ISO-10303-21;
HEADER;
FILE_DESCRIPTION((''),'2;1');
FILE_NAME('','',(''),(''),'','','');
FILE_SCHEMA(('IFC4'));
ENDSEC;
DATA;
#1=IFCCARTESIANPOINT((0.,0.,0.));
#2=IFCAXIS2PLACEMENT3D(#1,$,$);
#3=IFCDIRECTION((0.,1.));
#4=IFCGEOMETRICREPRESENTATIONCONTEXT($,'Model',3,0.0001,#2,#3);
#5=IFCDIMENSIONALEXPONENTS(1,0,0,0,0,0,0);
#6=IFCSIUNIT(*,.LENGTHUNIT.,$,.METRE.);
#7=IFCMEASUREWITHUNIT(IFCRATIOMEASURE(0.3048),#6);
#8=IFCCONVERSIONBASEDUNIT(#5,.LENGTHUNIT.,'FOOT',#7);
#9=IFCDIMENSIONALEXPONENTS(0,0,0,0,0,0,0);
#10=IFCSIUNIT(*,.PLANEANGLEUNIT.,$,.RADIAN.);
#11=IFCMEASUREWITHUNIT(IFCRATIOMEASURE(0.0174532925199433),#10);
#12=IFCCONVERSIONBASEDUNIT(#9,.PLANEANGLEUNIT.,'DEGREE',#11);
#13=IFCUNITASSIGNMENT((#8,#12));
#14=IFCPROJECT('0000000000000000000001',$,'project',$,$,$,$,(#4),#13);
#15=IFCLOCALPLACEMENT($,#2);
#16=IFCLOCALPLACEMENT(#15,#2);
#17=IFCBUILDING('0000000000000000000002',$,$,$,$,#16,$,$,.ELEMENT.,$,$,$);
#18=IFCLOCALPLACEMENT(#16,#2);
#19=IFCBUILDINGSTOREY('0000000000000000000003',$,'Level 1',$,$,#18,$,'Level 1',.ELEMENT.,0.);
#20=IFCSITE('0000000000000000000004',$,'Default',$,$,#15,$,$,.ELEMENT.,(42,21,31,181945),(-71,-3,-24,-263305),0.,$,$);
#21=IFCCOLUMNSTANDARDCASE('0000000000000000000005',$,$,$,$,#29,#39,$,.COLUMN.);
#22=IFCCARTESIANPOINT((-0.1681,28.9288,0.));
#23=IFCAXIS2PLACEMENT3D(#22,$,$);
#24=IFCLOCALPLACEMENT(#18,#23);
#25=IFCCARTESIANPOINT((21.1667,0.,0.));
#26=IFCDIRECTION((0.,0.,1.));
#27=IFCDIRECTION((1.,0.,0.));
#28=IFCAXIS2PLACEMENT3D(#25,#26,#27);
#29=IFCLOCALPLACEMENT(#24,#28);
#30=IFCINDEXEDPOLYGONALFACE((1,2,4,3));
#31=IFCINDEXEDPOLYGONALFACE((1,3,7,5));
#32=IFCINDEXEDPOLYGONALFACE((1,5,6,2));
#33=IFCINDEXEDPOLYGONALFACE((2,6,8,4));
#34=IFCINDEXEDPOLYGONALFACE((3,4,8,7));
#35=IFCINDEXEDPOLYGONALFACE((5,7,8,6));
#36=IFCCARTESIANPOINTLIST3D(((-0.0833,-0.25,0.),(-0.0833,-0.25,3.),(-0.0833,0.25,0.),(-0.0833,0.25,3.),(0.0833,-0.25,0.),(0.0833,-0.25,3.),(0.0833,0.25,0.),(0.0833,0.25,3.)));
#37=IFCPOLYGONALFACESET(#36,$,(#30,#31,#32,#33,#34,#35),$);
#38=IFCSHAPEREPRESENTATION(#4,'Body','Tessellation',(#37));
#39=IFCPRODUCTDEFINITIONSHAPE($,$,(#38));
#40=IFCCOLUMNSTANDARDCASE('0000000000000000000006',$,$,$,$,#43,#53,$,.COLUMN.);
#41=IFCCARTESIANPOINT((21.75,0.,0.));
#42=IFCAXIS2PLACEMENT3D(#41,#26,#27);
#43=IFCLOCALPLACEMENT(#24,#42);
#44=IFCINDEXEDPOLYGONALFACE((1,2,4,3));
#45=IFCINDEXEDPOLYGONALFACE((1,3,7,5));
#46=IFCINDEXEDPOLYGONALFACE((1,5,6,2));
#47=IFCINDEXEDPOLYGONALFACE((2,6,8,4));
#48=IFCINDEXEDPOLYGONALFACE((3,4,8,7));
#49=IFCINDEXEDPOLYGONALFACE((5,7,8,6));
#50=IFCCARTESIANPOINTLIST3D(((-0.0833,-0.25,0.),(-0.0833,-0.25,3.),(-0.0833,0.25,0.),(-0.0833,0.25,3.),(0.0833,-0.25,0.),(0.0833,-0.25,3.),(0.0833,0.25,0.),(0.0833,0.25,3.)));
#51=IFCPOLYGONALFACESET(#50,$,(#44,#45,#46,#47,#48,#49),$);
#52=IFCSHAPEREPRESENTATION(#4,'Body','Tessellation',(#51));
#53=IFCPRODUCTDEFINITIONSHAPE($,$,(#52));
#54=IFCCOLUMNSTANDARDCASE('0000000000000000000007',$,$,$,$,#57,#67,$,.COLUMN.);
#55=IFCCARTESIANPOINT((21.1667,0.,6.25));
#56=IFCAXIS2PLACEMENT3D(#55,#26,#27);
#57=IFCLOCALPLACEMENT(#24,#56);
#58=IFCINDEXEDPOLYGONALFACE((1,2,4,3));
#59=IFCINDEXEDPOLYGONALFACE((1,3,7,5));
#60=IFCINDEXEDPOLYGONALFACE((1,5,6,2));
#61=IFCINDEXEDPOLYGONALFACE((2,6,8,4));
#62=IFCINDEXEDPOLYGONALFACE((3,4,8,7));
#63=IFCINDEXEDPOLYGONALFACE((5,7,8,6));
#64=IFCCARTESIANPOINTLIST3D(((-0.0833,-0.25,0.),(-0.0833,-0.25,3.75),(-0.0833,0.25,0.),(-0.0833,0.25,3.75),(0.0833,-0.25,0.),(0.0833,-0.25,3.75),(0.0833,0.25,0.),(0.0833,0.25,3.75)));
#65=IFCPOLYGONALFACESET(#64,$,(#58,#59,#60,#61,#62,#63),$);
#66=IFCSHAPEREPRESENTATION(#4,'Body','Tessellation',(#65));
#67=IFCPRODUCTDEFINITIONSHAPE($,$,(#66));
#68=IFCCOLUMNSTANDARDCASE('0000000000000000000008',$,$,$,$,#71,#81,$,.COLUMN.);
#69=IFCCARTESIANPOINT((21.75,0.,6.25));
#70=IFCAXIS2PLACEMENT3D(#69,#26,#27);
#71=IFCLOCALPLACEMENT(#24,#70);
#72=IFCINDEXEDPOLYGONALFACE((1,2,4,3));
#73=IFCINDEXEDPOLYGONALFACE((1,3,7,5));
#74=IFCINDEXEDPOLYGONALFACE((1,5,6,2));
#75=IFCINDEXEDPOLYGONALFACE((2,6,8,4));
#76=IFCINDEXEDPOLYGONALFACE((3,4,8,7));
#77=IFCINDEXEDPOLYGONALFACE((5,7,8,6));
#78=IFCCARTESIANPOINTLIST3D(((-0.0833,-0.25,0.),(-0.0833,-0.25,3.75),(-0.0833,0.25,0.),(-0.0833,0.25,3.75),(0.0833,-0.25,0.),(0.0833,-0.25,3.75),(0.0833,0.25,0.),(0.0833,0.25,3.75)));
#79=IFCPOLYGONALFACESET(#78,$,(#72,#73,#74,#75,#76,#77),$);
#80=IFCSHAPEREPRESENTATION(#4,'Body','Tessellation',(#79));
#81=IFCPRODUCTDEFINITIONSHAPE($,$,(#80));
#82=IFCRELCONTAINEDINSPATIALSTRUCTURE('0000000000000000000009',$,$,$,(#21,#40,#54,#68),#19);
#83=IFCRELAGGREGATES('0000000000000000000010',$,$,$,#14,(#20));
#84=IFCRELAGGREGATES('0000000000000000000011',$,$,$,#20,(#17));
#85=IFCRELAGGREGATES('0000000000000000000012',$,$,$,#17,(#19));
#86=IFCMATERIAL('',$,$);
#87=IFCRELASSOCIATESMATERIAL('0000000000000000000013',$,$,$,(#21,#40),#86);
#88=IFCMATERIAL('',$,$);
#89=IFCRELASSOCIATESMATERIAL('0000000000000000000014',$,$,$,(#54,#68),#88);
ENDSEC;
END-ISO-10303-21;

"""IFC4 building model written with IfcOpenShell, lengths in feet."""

from ifc_helpers import new_model, entity, si_unit, converted_unit, direction, frame, origin, place, context, project, spatial, rectangle, extrude, material, element, save


model = new_model("IFC4")

# Units and contexts
model_context = context("Model", 3, precision=0.0001, world=origin(), true_north=direction((0.0, 1.0)))
ifc_project = project(units=[converted_unit("LENGTHUNIT", "FOOT", entity("IfcRatioMeasure", 0.3048), si_unit("LENGTHUNIT", "METRE"), dimensions=[1, 0, 0, 0, 0, 0, 0]), converted_unit("PLANEANGLEUNIT", "DEGREE", entity("IfcRatioMeasure", 0.0174532925199433), si_unit("PLANEANGLEUNIT", "RADIAN"), dimensions=[0, 0, 0, 0, 0, 0, 0])], contexts=[model_context])

# Site, building, storey
site_placement = place(None, origin())
site = spatial("IfcSite", under=ifc_project, at=site_placement, Name="Default", CompositionType="ELEMENT", RefLatitude=(42, 21, 31, 181945), RefLongitude=(-71, -3, -24, -263305), RefElevation=0.0)
building_placement = place(site_placement, origin())
building = spatial("IfcBuilding", under=site, at=building_placement, CompositionType="ELEMENT")
storey_placement = place(building_placement, origin())
storey = spatial("IfcBuildingStorey", under=building, at=storey_placement, Name="Level 1", LongName="Level 1", CompositionType="ELEMENT", Elevation=0.0)

# Columns
ifc_material_1 = material(Name="")
placement = place(storey_placement, frame((-0.1681, 28.9288, 0.0)))
for number, where, z_axis, x_axis in (
    (1, (21.1667, 0.0, 0.0), (0.0, 0.0, 1.0), (1.0, 0.0, 0.0)),
    (2, (21.75, 0.0, 0.0), (0.0, 0.0, 1.0), (1.0, 0.0, 0.0)),
):
    element("IfcColumnStandardCase", number, at=place(placement, frame(where, z_axis=z_axis, x_axis=x_axis)), inside=storey, material=ifc_material_1, PredefinedType="COLUMN", context=model_context, shape_type="SweptSolid", body=[
        extrude(rectangle(XDim=0.1667, YDim=0.5), origin(), (0.0, 0.0, 1.0), 3.0),
    ])
ifc_material_2 = material(Name="")
for number, where, z_axis, x_axis in (
    (3, (21.1667, 0.0, 6.25), (0.0, 0.0, 1.0), (1.0, 0.0, 0.0)),
    (4, (21.75, 0.0, 6.25), (0.0, 0.0, 1.0), (1.0, 0.0, 0.0)),
):
    element("IfcColumnStandardCase", number, at=place(placement, frame(where, z_axis=z_axis, x_axis=x_axis)), inside=storey, material=ifc_material_2, PredefinedType="COLUMN", context=model_context, shape_type="SweptSolid", body=[
        extrude(rectangle(XDim=0.1667, YDim=0.5), origin(), (0.0, 0.0, 1.0), 3.75),
    ])

save(model, "model.ifc")
